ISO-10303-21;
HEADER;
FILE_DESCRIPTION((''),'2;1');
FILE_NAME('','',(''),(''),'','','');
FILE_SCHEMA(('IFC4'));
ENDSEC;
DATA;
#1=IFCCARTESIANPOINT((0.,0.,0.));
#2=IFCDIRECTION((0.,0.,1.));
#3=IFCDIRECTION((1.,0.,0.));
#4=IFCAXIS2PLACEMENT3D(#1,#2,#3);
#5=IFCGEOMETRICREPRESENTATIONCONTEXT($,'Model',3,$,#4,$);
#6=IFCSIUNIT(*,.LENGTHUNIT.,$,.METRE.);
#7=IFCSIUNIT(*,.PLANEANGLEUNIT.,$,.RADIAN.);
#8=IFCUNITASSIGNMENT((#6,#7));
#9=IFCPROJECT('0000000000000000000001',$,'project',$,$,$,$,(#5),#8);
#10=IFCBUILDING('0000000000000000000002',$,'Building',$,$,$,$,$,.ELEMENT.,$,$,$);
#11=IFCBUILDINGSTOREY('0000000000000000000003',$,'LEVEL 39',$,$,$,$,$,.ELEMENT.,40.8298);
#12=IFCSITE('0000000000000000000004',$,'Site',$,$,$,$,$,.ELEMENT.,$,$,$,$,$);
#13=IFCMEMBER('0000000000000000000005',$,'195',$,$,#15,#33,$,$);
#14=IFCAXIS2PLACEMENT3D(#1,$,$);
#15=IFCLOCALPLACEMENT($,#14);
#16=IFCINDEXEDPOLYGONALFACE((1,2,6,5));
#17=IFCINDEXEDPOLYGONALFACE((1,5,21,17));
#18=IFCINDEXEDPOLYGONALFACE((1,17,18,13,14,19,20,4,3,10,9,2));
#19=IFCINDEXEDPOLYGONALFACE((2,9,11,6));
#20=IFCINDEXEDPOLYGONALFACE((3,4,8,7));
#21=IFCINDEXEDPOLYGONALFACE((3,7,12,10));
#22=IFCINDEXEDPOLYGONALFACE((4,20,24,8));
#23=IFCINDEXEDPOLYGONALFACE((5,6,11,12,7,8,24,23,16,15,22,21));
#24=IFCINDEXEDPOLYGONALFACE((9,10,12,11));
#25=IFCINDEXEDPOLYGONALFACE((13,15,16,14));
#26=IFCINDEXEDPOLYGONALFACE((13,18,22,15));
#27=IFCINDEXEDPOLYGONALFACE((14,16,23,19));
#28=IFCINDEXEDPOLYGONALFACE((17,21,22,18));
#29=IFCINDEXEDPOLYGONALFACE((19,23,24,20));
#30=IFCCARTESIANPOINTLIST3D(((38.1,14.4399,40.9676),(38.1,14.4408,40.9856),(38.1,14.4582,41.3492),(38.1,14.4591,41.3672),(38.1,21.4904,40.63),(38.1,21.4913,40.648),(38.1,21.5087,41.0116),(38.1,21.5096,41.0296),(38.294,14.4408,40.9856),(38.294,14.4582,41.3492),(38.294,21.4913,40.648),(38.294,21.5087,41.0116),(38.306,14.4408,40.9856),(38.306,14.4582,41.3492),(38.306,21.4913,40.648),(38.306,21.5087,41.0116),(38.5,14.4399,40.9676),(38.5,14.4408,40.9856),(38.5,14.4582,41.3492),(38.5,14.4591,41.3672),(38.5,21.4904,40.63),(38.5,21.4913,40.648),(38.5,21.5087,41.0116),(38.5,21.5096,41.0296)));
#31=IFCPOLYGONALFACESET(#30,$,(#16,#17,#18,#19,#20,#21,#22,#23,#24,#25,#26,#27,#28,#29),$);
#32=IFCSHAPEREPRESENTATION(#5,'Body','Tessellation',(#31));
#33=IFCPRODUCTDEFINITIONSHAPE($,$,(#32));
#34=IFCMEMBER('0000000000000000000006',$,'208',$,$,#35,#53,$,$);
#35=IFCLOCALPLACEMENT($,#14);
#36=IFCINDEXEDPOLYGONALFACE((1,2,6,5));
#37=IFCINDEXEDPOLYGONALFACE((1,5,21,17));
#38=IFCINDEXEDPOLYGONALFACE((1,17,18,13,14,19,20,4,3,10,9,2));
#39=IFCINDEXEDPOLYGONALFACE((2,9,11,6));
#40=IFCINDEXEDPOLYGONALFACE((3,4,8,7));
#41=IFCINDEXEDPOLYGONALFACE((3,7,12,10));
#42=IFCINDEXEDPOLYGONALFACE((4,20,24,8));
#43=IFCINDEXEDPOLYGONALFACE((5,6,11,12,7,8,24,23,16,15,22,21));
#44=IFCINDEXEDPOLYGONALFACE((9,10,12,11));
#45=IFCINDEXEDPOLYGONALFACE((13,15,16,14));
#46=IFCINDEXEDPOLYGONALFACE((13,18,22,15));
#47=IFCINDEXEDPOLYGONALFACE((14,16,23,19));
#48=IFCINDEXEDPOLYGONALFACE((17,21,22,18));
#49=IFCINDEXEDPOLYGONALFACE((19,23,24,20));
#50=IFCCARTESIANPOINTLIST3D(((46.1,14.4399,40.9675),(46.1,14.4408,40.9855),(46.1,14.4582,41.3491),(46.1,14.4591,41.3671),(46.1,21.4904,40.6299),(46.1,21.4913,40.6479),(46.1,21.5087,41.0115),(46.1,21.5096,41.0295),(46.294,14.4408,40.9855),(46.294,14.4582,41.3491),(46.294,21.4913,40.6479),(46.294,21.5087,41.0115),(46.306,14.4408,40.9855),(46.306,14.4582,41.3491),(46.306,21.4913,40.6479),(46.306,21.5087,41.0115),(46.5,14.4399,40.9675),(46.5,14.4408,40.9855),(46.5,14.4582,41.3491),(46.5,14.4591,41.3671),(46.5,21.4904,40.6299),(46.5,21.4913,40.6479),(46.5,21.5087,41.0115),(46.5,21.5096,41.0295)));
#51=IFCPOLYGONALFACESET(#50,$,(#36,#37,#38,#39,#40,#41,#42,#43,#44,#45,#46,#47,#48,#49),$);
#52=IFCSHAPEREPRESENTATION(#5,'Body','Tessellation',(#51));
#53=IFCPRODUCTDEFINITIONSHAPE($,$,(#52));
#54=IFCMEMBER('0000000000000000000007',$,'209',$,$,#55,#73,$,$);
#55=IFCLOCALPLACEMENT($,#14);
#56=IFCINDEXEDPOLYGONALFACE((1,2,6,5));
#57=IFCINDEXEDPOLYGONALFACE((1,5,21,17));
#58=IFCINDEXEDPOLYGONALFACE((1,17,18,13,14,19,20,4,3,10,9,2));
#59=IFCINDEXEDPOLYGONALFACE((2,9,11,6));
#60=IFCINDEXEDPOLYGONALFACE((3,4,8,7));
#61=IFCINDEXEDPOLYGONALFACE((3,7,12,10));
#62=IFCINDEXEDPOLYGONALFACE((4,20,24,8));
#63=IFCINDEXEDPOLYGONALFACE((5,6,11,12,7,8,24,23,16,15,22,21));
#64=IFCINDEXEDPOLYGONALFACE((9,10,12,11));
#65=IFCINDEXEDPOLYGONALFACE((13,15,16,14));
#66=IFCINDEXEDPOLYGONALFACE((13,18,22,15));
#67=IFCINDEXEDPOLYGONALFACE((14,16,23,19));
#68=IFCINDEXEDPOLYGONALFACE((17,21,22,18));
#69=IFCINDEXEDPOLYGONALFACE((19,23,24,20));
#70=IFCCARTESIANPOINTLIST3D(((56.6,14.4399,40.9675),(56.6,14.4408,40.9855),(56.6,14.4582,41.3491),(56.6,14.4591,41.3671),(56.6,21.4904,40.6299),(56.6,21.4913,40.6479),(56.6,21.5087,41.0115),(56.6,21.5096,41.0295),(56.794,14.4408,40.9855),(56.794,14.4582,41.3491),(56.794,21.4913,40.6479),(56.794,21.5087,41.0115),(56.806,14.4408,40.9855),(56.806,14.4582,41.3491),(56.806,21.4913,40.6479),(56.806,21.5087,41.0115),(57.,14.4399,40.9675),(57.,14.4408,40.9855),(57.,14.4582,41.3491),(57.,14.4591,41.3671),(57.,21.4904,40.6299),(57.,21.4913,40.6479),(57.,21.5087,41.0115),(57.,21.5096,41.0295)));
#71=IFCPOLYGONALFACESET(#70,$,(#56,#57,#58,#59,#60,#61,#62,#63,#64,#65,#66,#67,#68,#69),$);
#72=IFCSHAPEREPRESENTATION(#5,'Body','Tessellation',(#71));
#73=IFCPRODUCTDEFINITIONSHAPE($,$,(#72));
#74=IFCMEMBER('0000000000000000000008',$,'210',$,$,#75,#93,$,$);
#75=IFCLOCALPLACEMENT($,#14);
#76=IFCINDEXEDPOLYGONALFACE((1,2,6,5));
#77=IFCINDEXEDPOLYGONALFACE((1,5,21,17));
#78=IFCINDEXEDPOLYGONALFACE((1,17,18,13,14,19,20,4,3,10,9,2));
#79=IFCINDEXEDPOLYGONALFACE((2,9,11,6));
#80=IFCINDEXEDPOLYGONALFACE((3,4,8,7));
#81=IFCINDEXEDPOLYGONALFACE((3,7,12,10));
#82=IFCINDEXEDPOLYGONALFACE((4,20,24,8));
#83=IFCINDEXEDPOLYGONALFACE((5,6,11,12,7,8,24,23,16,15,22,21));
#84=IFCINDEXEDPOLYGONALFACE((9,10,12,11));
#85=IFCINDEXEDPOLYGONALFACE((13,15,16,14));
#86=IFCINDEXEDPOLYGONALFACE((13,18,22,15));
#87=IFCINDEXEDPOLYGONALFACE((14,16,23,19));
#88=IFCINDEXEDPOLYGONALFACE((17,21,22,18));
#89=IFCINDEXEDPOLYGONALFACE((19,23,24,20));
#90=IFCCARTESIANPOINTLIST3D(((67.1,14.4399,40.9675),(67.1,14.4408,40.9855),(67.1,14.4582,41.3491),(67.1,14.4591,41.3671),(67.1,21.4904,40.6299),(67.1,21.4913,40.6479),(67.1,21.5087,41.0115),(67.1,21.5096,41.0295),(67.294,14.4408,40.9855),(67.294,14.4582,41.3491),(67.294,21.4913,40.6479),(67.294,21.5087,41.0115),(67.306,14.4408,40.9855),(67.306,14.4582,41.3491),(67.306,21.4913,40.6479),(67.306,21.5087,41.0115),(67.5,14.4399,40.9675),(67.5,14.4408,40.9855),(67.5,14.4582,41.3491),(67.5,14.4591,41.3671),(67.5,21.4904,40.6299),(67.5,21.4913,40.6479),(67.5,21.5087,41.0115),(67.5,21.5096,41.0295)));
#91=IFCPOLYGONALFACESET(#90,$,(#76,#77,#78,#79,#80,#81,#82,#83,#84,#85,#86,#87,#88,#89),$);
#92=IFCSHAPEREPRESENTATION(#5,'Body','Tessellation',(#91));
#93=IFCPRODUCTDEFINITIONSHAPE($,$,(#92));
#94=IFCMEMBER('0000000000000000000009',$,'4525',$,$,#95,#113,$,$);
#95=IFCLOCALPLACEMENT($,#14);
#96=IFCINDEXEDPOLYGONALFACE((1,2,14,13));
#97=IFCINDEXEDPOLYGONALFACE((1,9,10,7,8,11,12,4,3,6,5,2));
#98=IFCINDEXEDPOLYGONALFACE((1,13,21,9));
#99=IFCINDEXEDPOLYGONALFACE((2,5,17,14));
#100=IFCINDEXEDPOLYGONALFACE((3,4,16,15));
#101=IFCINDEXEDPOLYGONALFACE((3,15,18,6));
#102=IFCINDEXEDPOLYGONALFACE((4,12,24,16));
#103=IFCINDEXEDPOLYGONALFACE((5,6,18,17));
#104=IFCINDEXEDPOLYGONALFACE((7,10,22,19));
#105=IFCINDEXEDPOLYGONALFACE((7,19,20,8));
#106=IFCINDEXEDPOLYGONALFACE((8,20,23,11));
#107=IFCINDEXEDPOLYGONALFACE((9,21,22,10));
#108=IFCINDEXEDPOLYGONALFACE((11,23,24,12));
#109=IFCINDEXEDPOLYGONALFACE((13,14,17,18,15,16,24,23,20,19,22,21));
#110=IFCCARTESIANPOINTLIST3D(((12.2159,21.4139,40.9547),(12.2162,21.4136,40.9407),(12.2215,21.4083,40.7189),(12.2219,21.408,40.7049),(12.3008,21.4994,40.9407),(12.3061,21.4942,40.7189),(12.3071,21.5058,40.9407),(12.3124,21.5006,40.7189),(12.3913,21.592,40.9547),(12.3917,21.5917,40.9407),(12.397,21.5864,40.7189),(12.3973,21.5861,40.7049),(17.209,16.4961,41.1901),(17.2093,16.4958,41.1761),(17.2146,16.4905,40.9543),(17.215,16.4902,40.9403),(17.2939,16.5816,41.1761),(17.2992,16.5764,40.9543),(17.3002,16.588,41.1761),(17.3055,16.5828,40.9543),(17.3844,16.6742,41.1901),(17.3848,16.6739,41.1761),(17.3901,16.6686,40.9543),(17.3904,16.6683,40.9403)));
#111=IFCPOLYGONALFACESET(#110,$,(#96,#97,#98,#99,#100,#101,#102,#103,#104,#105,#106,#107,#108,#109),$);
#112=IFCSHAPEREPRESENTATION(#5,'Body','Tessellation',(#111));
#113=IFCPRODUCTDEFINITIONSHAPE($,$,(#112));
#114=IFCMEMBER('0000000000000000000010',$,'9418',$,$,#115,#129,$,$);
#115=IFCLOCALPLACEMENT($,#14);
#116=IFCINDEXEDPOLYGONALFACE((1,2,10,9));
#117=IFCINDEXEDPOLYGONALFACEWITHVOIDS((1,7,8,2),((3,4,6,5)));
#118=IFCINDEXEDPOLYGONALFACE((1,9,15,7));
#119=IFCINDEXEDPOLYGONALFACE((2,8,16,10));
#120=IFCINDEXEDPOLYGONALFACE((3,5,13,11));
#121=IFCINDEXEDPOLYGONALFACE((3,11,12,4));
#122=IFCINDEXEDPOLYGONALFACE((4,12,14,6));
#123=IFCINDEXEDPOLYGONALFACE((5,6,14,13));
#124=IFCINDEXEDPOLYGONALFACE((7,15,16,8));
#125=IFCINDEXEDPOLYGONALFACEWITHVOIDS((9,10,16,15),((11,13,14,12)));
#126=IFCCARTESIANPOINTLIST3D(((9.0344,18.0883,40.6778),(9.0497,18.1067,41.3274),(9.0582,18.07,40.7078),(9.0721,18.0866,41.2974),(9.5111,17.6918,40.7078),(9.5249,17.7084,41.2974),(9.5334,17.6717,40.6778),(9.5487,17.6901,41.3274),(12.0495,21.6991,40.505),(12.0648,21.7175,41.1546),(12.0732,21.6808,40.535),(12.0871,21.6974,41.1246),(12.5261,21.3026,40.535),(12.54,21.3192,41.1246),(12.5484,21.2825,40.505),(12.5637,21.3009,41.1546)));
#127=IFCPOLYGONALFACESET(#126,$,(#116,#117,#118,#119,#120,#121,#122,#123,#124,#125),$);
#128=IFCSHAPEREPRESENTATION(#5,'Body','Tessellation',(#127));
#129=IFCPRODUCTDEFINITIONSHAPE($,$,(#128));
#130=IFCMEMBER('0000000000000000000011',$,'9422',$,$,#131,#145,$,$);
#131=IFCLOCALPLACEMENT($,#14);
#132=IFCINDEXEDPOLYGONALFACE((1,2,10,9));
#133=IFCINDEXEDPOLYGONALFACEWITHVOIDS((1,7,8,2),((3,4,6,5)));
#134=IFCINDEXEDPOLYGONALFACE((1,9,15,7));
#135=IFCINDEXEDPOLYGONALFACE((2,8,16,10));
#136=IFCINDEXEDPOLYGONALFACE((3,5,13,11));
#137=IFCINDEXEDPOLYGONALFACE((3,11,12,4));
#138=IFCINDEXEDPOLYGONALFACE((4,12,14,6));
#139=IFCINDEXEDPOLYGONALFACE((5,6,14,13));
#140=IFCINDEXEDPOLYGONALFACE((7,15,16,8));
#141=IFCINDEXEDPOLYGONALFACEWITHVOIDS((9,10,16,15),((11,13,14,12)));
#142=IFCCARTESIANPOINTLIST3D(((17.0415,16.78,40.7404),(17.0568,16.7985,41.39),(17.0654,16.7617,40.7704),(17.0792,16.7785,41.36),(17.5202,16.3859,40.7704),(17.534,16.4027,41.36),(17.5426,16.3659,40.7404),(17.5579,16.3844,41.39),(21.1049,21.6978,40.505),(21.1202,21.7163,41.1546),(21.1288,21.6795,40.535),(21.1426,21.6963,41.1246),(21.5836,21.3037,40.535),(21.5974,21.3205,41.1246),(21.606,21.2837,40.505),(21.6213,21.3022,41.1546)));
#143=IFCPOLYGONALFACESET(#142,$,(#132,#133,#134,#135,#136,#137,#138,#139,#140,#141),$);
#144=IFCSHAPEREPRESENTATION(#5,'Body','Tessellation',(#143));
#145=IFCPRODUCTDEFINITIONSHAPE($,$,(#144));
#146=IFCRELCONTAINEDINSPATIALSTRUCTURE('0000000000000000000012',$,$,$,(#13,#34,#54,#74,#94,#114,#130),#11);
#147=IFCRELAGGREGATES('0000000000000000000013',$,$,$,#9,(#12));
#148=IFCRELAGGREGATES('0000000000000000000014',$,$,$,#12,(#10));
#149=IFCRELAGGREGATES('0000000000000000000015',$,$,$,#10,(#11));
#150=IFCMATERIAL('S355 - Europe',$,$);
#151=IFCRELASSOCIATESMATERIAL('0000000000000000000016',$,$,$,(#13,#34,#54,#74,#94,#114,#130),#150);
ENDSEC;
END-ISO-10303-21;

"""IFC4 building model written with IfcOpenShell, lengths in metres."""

from ifc_helpers import new_model, si_unit, frame, origin_with_axes, origin_2d_with_axis, place, context, project, spatial, hollow_rectangle, i_section, extrude, material, material_profile, profile_set, profile_usage, element, save


model = new_model("IFC4")

# Units and contexts
model_context = context("Model", 3, world=origin_with_axes())
ifc_project = project(units=[si_unit("LENGTHUNIT", "METRE"), si_unit("PLANEANGLEUNIT", "RADIAN")], contexts=[model_context])

# Site, building, storey
site = spatial("IfcSite", under=ifc_project, Name="Site", CompositionType="ELEMENT")
building = spatial("IfcBuilding", under=site, Name="Building", CompositionType="ELEMENT")
storey = spatial("IfcBuildingStorey", under=building, Name="LEVEL 39", CompositionType="ELEMENT", Elevation=40.8298)

# Shared definitions
ifc_material = material(Name="S355 - Europe")

# Members
ifc_material_profile_1 = material_profile(ifc_material, i_section(OverallWidth=0.4, OverallDepth=0.4, WebThickness=0.012, FlangeThickness=0.018, at=origin_2d_with_axis()))
ifc_profile_set_1 = profile_set([ifc_material_profile_1])
ifc_profile_usage_1 = profile_usage(ifc_profile_set_1, cardinal=10)
member_1_placement = place(None, frame((38.3, 21.5, 40.8298), z_axis=(0.0, -0.998856, 0.047828), x_axis=(1.0, 0.0, 0.0)))
element("IfcMember", 1, at=member_1_placement, inside=storey, material=ifc_profile_usage_1, Name="195", context=model_context, shape_type="SweptSolid", body=[
    extrude(i_section(OverallWidth=0.4, OverallDepth=0.4, WebThickness=0.012, FlangeThickness=0.018, at=origin_2d_with_axis()), origin_with_axes(), (0.0, 0.0, 1.0), 7.0586),
])
ifc_material_profile_2 = material_profile(ifc_material, i_section(OverallWidth=0.4, OverallDepth=0.4, WebThickness=0.012, FlangeThickness=0.018, at=origin_2d_with_axis()))
ifc_profile_set_2 = profile_set([ifc_material_profile_2])
ifc_profile_usage_2 = profile_usage(ifc_profile_set_2, cardinal=10)
member_2_placement = place(None, frame((46.3, 14.4495, 41.1673), z_axis=(0.0, 0.998856, -0.047828), x_axis=(-1.0, 0.0, 0.0)))
element("IfcMember", 2, at=member_2_placement, inside=storey, material=ifc_profile_usage_2, Name="208", context=model_context, shape_type="SweptSolid", body=[
    extrude(i_section(OverallWidth=0.4, OverallDepth=0.4, WebThickness=0.012, FlangeThickness=0.018, at=origin_2d_with_axis()), origin_with_axes(), (0.0, 0.0, 1.0), 7.0586),
])
ifc_material_profile_3 = material_profile(ifc_material, i_section(OverallWidth=0.4, OverallDepth=0.4, WebThickness=0.012, FlangeThickness=0.018, at=origin_2d_with_axis()))
ifc_profile_set_3 = profile_set([ifc_material_profile_3])
ifc_profile_usage_3 = profile_usage(ifc_profile_set_3, cardinal=10)
member_3_placement = place(None, frame((56.8, 14.4495, 41.1673), z_axis=(0.0, 0.998856, -0.047828), x_axis=(-1.0, 0.0, 0.0)))
element("IfcMember", 3, at=member_3_placement, inside=storey, material=ifc_profile_usage_3, Name="209", context=model_context, shape_type="SweptSolid", body=[
    extrude(i_section(OverallWidth=0.4, OverallDepth=0.4, WebThickness=0.012, FlangeThickness=0.018, at=origin_2d_with_axis()), origin_with_axes(), (0.0, 0.0, 1.0), 7.0586),
])
ifc_material_profile_4 = material_profile(ifc_material, i_section(OverallWidth=0.4, OverallDepth=0.4, WebThickness=0.012, FlangeThickness=0.018, at=origin_2d_with_axis()))
ifc_profile_set_4 = profile_set([ifc_material_profile_4])
ifc_profile_usage_4 = profile_usage(ifc_profile_set_4, cardinal=10)
member_4_placement = place(None, frame((67.3, 14.4495, 41.1673), z_axis=(0.0, 0.998856, -0.047828), x_axis=(-1.0, 0.0, 0.0)))
element("IfcMember", 4, at=member_4_placement, inside=storey, material=ifc_profile_usage_4, Name="210", context=model_context, shape_type="SweptSolid", body=[
    extrude(i_section(OverallWidth=0.4, OverallDepth=0.4, WebThickness=0.012, FlangeThickness=0.018, at=origin_2d_with_axis()), origin_with_axes(), (0.0, 0.0, 1.0), 7.0586),
])
ifc_material_profile_5 = material_profile(ifc_material, i_section(OverallWidth=0.25, OverallDepth=0.25, WebThickness=0.009, FlangeThickness=0.014, at=origin_2d_with_axis()))
ifc_profile_set_5 = profile_set([ifc_material_profile_5])
ifc_profile_usage_5 = profile_usage(ifc_profile_set_5, cardinal=10)
member_5_placement = place(None, frame((12.3066, 21.5, 40.8298), z_axis=(0.712057, -0.701319, 0.03357), x_axis=(0.701671, 0.712501, 0.0)))
element("IfcMember", 5, at=member_5_placement, inside=storey, material=ifc_profile_usage_5, Name="4525", context=model_context, shape_type="SweptSolid", body=[
    extrude(i_section(OverallWidth=0.25, OverallDepth=0.25, WebThickness=0.009, FlangeThickness=0.014, at=origin_2d_with_axis()), origin_with_axes(), (0.0, 0.0, 1.0), 7.0122),
])
ifc_material_profile_6 = material_profile(ifc_material, hollow_rectangle(XDim=0.65, YDim=0.65, WallThickness=0.03, at=origin_2d_with_axis()))
ifc_profile_set_6 = profile_set([ifc_material_profile_6])
ifc_profile_usage_6 = profile_usage(ifc_profile_set_6, cardinal=10)
member_6_placement = place(None, frame((9.2916, 17.8892, 41.0026), z_axis=(0.64051, 0.767072, -0.036709), x_axis=(-0.767589, 0.640942, 0.0)))
element("IfcMember", 6, at=member_6_placement, inside=storey, material=ifc_profile_usage_6, Name="9418", context=model_context, shape_type="SweptSolid", body=[
    extrude(hollow_rectangle(XDim=0.65, YDim=0.65, WallThickness=0.03, at=origin_2d_with_axis()), origin_with_axes(), (0.0, 0.0, 1.0), 4.7073),
])
ifc_material_profile_7 = material_profile(ifc_material, hollow_rectangle(XDim=0.65, YDim=0.65, WallThickness=0.03, at=origin_2d_with_axis()))
ifc_profile_set_7 = profile_set([ifc_material_profile_7])
ifc_profile_usage_7 = profile_usage(ifc_profile_set_7, cardinal=10)
member_7_placement = place(None, frame((21.3631, 21.5, 40.8298), z_axis=(-0.636529, -0.770371, 0.036875), x_axis=(0.771137, -0.636669, 0.0)))
element("IfcMember", 7, at=member_7_placement, inside=storey, material=ifc_profile_usage_7, Name="9422", context=model_context, shape_type="SweptSolid", body=[
    extrude(hollow_rectangle(XDim=0.65, YDim=0.65, WallThickness=0.03, at=origin_2d_with_axis()), origin_with_axes(), (0.0, 0.0, 1.0), 6.3837),
])

save(model, "model.ifc")
